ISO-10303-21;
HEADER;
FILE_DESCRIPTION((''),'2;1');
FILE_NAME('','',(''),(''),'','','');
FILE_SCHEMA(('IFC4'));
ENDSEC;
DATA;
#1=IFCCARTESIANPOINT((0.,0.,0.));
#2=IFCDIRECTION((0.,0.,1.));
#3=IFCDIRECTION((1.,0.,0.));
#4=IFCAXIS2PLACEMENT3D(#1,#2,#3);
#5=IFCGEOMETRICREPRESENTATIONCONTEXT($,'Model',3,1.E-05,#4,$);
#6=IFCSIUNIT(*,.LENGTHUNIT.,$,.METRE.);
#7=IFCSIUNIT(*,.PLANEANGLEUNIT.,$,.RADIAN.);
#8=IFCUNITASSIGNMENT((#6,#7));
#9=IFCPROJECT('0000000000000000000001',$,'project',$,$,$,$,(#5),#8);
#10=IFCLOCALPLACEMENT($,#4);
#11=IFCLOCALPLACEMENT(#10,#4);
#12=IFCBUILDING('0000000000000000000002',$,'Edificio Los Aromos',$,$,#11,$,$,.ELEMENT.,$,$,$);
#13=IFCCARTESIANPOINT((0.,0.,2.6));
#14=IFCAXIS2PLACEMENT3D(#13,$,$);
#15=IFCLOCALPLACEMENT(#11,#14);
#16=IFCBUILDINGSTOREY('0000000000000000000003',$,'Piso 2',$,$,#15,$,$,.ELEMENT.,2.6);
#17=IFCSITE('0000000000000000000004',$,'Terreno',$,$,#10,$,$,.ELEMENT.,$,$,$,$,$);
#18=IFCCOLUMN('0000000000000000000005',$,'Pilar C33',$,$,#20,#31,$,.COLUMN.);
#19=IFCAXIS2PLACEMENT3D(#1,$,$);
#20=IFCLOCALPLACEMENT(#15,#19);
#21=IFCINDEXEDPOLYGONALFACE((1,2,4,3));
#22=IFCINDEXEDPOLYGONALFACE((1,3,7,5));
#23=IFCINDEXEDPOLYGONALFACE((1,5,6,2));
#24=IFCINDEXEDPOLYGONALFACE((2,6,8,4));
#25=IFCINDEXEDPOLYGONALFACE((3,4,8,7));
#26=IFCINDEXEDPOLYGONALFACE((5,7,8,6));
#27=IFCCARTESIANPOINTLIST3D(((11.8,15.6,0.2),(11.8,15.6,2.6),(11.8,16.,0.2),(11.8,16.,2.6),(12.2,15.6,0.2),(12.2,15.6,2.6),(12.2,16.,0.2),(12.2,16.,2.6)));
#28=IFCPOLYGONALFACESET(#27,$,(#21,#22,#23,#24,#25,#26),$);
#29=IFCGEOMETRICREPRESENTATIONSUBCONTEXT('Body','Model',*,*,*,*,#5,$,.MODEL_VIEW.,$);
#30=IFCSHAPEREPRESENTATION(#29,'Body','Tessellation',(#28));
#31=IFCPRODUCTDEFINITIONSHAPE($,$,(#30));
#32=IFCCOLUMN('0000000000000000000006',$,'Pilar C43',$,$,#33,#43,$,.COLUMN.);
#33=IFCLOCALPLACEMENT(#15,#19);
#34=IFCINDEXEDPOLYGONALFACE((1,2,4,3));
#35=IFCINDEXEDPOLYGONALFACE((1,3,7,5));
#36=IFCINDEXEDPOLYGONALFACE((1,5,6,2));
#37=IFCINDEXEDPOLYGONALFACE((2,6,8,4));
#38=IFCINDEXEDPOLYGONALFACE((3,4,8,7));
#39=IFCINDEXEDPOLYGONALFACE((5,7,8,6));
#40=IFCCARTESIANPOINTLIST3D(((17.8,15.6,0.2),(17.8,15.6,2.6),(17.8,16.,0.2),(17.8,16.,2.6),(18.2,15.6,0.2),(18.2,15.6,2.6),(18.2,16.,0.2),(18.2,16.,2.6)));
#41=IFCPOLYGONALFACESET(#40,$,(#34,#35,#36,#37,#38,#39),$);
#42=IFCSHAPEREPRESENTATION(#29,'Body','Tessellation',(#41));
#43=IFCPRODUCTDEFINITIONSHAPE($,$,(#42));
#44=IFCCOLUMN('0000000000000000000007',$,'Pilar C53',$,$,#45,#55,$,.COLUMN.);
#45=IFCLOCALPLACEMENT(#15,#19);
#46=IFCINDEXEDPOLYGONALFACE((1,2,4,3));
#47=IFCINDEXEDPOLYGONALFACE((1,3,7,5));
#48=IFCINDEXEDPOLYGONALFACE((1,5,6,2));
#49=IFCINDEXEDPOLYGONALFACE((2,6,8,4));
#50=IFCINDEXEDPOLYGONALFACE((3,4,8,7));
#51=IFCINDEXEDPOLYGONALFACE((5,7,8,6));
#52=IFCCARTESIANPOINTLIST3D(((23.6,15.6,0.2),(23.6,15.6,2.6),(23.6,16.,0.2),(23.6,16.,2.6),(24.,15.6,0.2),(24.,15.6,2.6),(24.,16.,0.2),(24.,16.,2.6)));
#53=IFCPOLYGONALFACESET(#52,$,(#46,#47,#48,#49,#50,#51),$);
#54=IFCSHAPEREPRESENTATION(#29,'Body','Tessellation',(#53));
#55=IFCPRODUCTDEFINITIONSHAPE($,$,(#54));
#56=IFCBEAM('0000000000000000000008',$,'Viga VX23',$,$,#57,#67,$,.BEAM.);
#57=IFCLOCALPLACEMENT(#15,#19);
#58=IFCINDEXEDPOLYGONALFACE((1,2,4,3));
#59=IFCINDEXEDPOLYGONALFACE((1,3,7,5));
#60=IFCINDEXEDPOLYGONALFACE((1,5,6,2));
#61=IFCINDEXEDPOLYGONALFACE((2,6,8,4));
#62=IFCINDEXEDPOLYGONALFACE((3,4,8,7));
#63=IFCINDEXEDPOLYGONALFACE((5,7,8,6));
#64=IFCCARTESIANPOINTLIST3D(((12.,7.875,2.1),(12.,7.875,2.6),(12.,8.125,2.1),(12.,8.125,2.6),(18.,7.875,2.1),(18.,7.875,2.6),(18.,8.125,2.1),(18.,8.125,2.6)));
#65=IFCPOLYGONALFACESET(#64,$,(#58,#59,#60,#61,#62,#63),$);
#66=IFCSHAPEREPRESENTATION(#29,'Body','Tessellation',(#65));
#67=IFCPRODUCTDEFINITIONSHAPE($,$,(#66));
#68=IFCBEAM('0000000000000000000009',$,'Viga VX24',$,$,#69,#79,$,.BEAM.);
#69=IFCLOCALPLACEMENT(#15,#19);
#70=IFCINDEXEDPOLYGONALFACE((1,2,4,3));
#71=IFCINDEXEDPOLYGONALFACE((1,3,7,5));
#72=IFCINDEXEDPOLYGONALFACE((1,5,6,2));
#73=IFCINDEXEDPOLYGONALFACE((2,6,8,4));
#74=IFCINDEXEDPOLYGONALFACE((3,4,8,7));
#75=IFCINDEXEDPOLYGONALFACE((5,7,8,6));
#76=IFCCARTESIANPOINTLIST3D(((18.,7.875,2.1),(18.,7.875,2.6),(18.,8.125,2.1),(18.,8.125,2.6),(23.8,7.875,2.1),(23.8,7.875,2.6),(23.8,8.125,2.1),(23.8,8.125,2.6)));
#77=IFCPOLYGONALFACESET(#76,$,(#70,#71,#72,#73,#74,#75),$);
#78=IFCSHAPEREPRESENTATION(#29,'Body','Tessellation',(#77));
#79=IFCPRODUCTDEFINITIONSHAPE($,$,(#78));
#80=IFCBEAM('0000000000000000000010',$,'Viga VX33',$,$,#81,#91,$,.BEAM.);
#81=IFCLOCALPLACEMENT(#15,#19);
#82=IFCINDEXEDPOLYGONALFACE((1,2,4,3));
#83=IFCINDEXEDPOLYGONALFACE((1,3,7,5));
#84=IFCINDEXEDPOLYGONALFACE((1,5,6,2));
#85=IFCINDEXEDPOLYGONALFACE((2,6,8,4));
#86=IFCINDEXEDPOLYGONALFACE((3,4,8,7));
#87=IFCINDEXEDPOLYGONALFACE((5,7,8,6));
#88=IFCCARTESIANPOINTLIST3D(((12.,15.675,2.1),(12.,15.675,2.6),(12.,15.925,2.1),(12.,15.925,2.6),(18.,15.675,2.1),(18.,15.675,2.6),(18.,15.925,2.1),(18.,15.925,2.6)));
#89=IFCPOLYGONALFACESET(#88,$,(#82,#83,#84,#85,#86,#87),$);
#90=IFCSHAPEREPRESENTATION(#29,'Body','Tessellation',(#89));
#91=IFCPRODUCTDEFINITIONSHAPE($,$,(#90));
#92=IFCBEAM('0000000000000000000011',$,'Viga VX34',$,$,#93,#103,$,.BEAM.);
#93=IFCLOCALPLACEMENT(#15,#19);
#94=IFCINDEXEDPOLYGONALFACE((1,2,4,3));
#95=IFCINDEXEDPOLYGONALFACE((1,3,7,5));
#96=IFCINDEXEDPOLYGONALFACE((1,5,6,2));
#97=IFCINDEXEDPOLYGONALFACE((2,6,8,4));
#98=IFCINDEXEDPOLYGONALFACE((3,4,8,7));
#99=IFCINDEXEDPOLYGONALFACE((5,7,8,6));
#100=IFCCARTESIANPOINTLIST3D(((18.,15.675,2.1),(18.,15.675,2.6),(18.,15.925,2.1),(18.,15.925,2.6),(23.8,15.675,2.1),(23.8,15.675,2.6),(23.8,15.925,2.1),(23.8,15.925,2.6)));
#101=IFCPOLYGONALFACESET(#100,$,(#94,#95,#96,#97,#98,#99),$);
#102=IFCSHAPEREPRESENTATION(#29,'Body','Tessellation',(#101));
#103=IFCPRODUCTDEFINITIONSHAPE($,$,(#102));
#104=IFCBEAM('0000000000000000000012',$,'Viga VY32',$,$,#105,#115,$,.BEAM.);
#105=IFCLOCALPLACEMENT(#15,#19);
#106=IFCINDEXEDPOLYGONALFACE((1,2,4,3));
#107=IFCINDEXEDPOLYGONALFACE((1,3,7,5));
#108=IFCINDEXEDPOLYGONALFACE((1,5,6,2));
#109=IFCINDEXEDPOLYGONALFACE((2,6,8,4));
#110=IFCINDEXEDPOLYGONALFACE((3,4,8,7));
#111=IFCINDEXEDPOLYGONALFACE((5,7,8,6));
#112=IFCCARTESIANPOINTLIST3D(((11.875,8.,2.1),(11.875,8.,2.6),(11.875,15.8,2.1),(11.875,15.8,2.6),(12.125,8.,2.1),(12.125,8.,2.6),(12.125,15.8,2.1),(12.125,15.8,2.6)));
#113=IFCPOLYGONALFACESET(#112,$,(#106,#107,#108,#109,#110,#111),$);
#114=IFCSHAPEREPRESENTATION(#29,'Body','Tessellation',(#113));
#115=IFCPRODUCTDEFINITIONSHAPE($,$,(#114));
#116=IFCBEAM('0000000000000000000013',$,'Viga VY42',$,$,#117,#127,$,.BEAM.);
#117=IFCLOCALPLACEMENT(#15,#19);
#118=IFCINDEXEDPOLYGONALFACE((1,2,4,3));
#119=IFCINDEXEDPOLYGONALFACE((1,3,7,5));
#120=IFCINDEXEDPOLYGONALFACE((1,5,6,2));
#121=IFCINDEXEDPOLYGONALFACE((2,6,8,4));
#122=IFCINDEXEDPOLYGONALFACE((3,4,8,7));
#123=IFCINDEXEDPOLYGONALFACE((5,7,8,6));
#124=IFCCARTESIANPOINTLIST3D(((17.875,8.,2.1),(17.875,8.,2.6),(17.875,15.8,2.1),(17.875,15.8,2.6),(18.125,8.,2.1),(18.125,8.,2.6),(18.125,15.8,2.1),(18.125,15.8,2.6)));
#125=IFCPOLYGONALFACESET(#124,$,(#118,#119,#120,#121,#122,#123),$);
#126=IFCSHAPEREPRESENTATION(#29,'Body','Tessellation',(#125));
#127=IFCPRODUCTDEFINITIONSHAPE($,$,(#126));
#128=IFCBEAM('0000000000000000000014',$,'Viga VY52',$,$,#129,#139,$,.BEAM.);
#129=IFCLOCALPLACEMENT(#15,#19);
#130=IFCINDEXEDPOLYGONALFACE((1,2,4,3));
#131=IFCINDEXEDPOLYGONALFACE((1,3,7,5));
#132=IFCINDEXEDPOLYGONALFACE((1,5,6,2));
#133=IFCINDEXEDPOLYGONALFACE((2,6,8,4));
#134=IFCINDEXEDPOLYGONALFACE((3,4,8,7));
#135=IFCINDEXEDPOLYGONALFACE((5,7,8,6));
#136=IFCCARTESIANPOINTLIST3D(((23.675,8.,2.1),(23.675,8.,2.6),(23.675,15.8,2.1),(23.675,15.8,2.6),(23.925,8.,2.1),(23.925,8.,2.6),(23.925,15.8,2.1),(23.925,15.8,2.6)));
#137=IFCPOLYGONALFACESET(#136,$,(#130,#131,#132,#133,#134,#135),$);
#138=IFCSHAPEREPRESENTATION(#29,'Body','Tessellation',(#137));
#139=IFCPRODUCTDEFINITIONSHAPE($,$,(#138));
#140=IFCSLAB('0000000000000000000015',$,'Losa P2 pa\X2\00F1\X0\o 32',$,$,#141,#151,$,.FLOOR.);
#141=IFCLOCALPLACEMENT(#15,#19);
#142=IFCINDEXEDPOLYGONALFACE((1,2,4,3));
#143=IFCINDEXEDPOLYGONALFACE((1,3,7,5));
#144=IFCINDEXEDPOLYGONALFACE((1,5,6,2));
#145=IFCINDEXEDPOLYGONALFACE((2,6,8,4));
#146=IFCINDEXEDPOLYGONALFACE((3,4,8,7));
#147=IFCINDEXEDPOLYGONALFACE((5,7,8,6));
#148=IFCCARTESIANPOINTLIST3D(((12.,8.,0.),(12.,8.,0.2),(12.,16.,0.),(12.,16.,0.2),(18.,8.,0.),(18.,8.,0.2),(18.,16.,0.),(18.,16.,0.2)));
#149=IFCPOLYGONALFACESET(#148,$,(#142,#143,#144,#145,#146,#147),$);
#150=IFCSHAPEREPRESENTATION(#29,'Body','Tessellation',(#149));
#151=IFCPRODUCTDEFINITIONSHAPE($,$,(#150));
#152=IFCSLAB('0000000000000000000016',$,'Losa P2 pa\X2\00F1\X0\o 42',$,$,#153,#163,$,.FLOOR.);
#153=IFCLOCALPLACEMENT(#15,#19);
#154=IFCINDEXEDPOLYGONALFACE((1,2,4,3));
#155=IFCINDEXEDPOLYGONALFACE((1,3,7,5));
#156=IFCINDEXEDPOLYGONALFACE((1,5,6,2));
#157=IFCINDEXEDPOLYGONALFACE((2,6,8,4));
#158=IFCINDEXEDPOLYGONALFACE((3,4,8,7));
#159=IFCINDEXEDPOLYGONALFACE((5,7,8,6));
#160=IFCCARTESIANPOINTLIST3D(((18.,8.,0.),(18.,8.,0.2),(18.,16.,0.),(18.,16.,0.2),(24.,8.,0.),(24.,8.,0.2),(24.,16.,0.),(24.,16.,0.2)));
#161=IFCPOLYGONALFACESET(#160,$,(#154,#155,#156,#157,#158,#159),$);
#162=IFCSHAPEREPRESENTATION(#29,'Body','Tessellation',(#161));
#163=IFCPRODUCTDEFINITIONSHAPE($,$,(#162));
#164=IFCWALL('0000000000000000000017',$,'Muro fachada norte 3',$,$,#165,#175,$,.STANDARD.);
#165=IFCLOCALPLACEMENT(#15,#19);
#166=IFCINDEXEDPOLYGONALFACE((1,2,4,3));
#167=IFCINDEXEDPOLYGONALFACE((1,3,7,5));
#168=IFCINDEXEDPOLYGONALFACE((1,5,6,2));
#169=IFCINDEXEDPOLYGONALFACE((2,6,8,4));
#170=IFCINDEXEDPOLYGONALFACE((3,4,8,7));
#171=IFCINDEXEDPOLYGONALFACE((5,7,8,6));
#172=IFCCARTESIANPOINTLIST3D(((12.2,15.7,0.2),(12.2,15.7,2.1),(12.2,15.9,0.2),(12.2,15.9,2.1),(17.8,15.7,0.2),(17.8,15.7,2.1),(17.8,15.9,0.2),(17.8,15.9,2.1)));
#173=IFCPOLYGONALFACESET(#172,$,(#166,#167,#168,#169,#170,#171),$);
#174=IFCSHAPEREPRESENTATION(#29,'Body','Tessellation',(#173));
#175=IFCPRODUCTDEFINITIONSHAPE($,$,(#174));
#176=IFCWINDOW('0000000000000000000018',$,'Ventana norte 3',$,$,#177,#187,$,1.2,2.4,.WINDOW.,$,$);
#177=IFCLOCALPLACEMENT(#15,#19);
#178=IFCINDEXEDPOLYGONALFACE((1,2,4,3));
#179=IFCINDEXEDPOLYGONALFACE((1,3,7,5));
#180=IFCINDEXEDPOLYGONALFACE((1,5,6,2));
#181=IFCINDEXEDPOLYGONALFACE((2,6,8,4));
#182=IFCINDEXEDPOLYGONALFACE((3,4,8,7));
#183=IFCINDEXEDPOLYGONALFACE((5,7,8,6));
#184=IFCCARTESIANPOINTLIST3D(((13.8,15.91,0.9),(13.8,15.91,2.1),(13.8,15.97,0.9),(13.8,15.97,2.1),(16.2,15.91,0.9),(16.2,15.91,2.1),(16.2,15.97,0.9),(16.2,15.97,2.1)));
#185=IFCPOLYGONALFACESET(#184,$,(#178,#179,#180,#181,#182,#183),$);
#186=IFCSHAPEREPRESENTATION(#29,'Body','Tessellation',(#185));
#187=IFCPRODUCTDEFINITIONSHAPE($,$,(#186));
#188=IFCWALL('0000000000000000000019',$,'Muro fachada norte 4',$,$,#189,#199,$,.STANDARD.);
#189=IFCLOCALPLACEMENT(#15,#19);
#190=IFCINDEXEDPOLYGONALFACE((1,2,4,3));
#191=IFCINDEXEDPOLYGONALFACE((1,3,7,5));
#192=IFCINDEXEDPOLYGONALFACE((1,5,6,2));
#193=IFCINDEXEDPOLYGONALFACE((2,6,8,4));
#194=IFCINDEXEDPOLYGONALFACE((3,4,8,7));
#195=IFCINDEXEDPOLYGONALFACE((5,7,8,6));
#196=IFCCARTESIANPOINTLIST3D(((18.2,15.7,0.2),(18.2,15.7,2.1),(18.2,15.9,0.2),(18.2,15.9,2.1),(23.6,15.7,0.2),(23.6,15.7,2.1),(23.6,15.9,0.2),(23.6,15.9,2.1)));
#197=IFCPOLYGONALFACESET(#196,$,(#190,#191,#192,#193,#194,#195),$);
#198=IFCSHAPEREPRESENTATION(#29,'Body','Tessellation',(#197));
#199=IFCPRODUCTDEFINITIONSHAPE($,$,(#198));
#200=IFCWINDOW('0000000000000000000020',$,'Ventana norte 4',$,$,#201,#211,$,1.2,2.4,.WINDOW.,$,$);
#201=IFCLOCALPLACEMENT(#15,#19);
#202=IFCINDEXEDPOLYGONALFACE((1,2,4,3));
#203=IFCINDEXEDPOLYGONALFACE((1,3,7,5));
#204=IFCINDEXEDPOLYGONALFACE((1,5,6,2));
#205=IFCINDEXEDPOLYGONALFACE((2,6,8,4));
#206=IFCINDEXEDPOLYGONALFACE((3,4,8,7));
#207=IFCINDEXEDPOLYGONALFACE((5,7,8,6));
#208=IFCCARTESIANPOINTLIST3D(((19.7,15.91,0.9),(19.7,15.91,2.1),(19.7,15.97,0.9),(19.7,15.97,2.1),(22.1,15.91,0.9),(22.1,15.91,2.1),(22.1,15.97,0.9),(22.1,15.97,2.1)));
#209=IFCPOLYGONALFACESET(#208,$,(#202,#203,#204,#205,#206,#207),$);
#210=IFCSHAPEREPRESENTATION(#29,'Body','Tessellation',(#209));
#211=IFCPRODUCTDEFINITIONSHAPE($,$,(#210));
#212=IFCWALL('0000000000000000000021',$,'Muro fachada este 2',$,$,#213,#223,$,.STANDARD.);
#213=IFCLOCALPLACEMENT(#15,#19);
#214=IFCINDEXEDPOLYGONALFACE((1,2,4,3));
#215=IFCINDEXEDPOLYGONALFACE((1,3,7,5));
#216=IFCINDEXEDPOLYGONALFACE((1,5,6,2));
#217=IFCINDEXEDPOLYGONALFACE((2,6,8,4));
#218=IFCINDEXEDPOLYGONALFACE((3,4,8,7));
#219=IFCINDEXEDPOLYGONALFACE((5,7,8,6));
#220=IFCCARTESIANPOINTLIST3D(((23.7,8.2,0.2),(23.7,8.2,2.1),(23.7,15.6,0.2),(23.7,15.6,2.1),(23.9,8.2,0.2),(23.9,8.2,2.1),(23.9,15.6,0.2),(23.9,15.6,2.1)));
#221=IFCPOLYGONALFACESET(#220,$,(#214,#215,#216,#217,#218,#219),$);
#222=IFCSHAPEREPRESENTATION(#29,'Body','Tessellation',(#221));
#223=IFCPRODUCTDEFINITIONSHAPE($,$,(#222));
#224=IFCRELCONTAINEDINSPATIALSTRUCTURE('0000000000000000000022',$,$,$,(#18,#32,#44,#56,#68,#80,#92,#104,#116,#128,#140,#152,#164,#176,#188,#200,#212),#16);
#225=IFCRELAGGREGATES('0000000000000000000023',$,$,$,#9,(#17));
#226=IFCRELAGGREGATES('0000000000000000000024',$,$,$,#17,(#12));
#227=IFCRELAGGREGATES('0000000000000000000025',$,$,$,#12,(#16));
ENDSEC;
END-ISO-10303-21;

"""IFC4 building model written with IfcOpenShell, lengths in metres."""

from ifc_helpers import new_model, si_unit, frame, frame_2d, origin_with_axes, place, context, subcontext, project, spatial, rectangle, extrude, element, save


model = new_model("IFC4")

# Units and contexts
model_context = context("Model", 3, precision=1e-05, world=origin_with_axes())
body_context = subcontext(model_context, "Body", "Model", "MODEL_VIEW")
ifc_project = project(units=[si_unit("LENGTHUNIT", "METRE"), si_unit("PLANEANGLEUNIT", "RADIAN")], contexts=[model_context])

# Site, building, storey
site_placement = place(None, origin_with_axes())
site = spatial("IfcSite", under=ifc_project, at=site_placement, Name="Terreno", CompositionType="ELEMENT")
building_placement = place(site_placement, origin_with_axes())
building = spatial("IfcBuilding", under=site, at=building_placement, Name="Edificio Los Aromos", CompositionType="ELEMENT")
storey_placement = place(building_placement, frame((0.0, 0.0, 2.6)))
storey = spatial("IfcBuildingStorey", under=building, at=storey_placement, Name="Piso 2", CompositionType="ELEMENT", Elevation=2.6)

# Columns
for number, where, name in (
    (1, (11.8, 15.6, 0.2), "Pilar C33"),
    (2, (17.8, 15.6, 0.2), "Pilar C43"),
    (3, (23.6, 15.6, 0.2), "Pilar C53"),
):
    element("IfcColumn", number, at=place(storey_placement, frame(where)), inside=storey, Name=name, PredefinedType="COLUMN", context=body_context, shape_type="SweptSolid", body=[
        extrude(rectangle(XDim=0.4, YDim=0.4, at=frame_2d((0.2, 0.2))), origin_with_axes(), (0.0, 0.0, 1.0), 2.4),
    ])

# Beams
beam_1_placement = place(storey_placement, frame((12.0, 7.875, 2.1)))
element("IfcBeam", 4, at=beam_1_placement, inside=storey, Name="Viga VX23", PredefinedType="BEAM", context=body_context, shape_type="SweptSolid", body=[
    extrude(rectangle(XDim=6.0, YDim=0.25, at=frame_2d((3.0, 0.125))), origin_with_axes(), (0.0, 0.0, 1.0), 0.5),
])
beam_2_placement = place(storey_placement, frame((18.0, 7.875, 2.1)))
element("IfcBeam", 5, at=beam_2_placement, inside=storey, Name="Viga VX24", PredefinedType="BEAM", context=body_context, shape_type="SweptSolid", body=[
    extrude(rectangle(XDim=5.8, YDim=0.25, at=frame_2d((2.9, 0.125))), origin_with_axes(), (0.0, 0.0, 1.0), 0.5),
])
beam_3_placement = place(storey_placement, frame((12.0, 15.675, 2.1)))
element("IfcBeam", 6, at=beam_3_placement, inside=storey, Name="Viga VX33", PredefinedType="BEAM", context=body_context, shape_type="SweptSolid", body=[
    extrude(rectangle(XDim=6.0, YDim=0.25, at=frame_2d((3.0, 0.125))), origin_with_axes(), (0.0, 0.0, 1.0), 0.5),
])
beam_4_placement = place(storey_placement, frame((18.0, 15.675, 2.1)))
element("IfcBeam", 7, at=beam_4_placement, inside=storey, Name="Viga VX34", PredefinedType="BEAM", context=body_context, shape_type="SweptSolid", body=[
    extrude(rectangle(XDim=5.8, YDim=0.25, at=frame_2d((2.9, 0.125))), origin_with_axes(), (0.0, 0.0, 1.0), 0.5),
])
for number, where, name in (
    (8, (11.875, 8.0, 2.1), "Viga VY32"),
    (9, (17.875, 8.0, 2.1), "Viga VY42"),
    (10, (23.675, 8.0, 2.1), "Viga VY52"),
):
    element("IfcBeam", number, at=place(storey_placement, frame(where)), inside=storey, Name=name, PredefinedType="BEAM", context=body_context, shape_type="SweptSolid", body=[
        extrude(rectangle(XDim=0.25, YDim=7.8, at=frame_2d((0.125, 3.9))), origin_with_axes(), (0.0, 0.0, 1.0), 0.5),
    ])

# Slabs
for number, where, name in (
    (11, (12.0, 8.0, 0.0), "Losa P2 paño 32"),
    (12, (18.0, 8.0, 0.0), "Losa P2 paño 42"),
):
    element("IfcSlab", number, at=place(storey_placement, frame(where)), inside=storey, Name=name, PredefinedType="FLOOR", context=body_context, shape_type="SweptSolid", body=[
        extrude(rectangle(XDim=6.0, YDim=8.0, at=frame_2d((3.0, 4.0))), origin_with_axes(), (0.0, 0.0, 1.0), 0.2),
    ])

# Wall
wall_1_placement = place(storey_placement, frame((12.2, 15.7, 0.2)))
element("IfcWall", 13, at=wall_1_placement, inside=storey, Name="Muro fachada norte 3", PredefinedType="STANDARD", context=body_context, shape_type="SweptSolid", body=[
    extrude(rectangle(XDim=5.6, YDim=0.2, at=frame_2d((2.8, 0.1))), origin_with_axes(), (0.0, 0.0, 1.0), 1.9),
])

# Window
window_1_placement = place(storey_placement, frame((13.8, 15.91, 0.9)))
element("IfcWindow", 14, at=window_1_placement, inside=storey, Name="Ventana norte 3", OverallHeight=1.2, OverallWidth=2.4, PredefinedType="WINDOW", context=body_context, shape_type="SweptSolid", body=[
    extrude(rectangle(XDim=2.4, YDim=0.06, at=frame_2d((1.2, 0.03))), origin_with_axes(), (0.0, 0.0, 1.0), 1.2),
])

# Wall
wall_2_placement = place(storey_placement, frame((18.2, 15.7, 0.2)))
element("IfcWall", 15, at=wall_2_placement, inside=storey, Name="Muro fachada norte 4", PredefinedType="STANDARD", context=body_context, shape_type="SweptSolid", body=[
    extrude(rectangle(XDim=5.4, YDim=0.2, at=frame_2d((2.7, 0.1))), origin_with_axes(), (0.0, 0.0, 1.0), 1.9),
])

# Window
window_2_placement = place(storey_placement, frame((19.7, 15.91, 0.9)))
element("IfcWindow", 16, at=window_2_placement, inside=storey, Name="Ventana norte 4", OverallHeight=1.2, OverallWidth=2.4, PredefinedType="WINDOW", context=body_context, shape_type="SweptSolid", body=[
    extrude(rectangle(XDim=2.4, YDim=0.06, at=frame_2d((1.2, 0.03))), origin_with_axes(), (0.0, 0.0, 1.0), 1.2),
])

# Wall
wall_3_placement = place(storey_placement, frame((23.7, 8.2, 0.2)))
element("IfcWall", 17, at=wall_3_placement, inside=storey, Name="Muro fachada este 2", PredefinedType="STANDARD", context=body_context, shape_type="SweptSolid", body=[
    extrude(rectangle(XDim=0.2, YDim=7.4, at=frame_2d((0.1, 3.7))), origin_with_axes(), (0.0, 0.0, 1.0), 1.9),
])

save(model, "model.ifc")
